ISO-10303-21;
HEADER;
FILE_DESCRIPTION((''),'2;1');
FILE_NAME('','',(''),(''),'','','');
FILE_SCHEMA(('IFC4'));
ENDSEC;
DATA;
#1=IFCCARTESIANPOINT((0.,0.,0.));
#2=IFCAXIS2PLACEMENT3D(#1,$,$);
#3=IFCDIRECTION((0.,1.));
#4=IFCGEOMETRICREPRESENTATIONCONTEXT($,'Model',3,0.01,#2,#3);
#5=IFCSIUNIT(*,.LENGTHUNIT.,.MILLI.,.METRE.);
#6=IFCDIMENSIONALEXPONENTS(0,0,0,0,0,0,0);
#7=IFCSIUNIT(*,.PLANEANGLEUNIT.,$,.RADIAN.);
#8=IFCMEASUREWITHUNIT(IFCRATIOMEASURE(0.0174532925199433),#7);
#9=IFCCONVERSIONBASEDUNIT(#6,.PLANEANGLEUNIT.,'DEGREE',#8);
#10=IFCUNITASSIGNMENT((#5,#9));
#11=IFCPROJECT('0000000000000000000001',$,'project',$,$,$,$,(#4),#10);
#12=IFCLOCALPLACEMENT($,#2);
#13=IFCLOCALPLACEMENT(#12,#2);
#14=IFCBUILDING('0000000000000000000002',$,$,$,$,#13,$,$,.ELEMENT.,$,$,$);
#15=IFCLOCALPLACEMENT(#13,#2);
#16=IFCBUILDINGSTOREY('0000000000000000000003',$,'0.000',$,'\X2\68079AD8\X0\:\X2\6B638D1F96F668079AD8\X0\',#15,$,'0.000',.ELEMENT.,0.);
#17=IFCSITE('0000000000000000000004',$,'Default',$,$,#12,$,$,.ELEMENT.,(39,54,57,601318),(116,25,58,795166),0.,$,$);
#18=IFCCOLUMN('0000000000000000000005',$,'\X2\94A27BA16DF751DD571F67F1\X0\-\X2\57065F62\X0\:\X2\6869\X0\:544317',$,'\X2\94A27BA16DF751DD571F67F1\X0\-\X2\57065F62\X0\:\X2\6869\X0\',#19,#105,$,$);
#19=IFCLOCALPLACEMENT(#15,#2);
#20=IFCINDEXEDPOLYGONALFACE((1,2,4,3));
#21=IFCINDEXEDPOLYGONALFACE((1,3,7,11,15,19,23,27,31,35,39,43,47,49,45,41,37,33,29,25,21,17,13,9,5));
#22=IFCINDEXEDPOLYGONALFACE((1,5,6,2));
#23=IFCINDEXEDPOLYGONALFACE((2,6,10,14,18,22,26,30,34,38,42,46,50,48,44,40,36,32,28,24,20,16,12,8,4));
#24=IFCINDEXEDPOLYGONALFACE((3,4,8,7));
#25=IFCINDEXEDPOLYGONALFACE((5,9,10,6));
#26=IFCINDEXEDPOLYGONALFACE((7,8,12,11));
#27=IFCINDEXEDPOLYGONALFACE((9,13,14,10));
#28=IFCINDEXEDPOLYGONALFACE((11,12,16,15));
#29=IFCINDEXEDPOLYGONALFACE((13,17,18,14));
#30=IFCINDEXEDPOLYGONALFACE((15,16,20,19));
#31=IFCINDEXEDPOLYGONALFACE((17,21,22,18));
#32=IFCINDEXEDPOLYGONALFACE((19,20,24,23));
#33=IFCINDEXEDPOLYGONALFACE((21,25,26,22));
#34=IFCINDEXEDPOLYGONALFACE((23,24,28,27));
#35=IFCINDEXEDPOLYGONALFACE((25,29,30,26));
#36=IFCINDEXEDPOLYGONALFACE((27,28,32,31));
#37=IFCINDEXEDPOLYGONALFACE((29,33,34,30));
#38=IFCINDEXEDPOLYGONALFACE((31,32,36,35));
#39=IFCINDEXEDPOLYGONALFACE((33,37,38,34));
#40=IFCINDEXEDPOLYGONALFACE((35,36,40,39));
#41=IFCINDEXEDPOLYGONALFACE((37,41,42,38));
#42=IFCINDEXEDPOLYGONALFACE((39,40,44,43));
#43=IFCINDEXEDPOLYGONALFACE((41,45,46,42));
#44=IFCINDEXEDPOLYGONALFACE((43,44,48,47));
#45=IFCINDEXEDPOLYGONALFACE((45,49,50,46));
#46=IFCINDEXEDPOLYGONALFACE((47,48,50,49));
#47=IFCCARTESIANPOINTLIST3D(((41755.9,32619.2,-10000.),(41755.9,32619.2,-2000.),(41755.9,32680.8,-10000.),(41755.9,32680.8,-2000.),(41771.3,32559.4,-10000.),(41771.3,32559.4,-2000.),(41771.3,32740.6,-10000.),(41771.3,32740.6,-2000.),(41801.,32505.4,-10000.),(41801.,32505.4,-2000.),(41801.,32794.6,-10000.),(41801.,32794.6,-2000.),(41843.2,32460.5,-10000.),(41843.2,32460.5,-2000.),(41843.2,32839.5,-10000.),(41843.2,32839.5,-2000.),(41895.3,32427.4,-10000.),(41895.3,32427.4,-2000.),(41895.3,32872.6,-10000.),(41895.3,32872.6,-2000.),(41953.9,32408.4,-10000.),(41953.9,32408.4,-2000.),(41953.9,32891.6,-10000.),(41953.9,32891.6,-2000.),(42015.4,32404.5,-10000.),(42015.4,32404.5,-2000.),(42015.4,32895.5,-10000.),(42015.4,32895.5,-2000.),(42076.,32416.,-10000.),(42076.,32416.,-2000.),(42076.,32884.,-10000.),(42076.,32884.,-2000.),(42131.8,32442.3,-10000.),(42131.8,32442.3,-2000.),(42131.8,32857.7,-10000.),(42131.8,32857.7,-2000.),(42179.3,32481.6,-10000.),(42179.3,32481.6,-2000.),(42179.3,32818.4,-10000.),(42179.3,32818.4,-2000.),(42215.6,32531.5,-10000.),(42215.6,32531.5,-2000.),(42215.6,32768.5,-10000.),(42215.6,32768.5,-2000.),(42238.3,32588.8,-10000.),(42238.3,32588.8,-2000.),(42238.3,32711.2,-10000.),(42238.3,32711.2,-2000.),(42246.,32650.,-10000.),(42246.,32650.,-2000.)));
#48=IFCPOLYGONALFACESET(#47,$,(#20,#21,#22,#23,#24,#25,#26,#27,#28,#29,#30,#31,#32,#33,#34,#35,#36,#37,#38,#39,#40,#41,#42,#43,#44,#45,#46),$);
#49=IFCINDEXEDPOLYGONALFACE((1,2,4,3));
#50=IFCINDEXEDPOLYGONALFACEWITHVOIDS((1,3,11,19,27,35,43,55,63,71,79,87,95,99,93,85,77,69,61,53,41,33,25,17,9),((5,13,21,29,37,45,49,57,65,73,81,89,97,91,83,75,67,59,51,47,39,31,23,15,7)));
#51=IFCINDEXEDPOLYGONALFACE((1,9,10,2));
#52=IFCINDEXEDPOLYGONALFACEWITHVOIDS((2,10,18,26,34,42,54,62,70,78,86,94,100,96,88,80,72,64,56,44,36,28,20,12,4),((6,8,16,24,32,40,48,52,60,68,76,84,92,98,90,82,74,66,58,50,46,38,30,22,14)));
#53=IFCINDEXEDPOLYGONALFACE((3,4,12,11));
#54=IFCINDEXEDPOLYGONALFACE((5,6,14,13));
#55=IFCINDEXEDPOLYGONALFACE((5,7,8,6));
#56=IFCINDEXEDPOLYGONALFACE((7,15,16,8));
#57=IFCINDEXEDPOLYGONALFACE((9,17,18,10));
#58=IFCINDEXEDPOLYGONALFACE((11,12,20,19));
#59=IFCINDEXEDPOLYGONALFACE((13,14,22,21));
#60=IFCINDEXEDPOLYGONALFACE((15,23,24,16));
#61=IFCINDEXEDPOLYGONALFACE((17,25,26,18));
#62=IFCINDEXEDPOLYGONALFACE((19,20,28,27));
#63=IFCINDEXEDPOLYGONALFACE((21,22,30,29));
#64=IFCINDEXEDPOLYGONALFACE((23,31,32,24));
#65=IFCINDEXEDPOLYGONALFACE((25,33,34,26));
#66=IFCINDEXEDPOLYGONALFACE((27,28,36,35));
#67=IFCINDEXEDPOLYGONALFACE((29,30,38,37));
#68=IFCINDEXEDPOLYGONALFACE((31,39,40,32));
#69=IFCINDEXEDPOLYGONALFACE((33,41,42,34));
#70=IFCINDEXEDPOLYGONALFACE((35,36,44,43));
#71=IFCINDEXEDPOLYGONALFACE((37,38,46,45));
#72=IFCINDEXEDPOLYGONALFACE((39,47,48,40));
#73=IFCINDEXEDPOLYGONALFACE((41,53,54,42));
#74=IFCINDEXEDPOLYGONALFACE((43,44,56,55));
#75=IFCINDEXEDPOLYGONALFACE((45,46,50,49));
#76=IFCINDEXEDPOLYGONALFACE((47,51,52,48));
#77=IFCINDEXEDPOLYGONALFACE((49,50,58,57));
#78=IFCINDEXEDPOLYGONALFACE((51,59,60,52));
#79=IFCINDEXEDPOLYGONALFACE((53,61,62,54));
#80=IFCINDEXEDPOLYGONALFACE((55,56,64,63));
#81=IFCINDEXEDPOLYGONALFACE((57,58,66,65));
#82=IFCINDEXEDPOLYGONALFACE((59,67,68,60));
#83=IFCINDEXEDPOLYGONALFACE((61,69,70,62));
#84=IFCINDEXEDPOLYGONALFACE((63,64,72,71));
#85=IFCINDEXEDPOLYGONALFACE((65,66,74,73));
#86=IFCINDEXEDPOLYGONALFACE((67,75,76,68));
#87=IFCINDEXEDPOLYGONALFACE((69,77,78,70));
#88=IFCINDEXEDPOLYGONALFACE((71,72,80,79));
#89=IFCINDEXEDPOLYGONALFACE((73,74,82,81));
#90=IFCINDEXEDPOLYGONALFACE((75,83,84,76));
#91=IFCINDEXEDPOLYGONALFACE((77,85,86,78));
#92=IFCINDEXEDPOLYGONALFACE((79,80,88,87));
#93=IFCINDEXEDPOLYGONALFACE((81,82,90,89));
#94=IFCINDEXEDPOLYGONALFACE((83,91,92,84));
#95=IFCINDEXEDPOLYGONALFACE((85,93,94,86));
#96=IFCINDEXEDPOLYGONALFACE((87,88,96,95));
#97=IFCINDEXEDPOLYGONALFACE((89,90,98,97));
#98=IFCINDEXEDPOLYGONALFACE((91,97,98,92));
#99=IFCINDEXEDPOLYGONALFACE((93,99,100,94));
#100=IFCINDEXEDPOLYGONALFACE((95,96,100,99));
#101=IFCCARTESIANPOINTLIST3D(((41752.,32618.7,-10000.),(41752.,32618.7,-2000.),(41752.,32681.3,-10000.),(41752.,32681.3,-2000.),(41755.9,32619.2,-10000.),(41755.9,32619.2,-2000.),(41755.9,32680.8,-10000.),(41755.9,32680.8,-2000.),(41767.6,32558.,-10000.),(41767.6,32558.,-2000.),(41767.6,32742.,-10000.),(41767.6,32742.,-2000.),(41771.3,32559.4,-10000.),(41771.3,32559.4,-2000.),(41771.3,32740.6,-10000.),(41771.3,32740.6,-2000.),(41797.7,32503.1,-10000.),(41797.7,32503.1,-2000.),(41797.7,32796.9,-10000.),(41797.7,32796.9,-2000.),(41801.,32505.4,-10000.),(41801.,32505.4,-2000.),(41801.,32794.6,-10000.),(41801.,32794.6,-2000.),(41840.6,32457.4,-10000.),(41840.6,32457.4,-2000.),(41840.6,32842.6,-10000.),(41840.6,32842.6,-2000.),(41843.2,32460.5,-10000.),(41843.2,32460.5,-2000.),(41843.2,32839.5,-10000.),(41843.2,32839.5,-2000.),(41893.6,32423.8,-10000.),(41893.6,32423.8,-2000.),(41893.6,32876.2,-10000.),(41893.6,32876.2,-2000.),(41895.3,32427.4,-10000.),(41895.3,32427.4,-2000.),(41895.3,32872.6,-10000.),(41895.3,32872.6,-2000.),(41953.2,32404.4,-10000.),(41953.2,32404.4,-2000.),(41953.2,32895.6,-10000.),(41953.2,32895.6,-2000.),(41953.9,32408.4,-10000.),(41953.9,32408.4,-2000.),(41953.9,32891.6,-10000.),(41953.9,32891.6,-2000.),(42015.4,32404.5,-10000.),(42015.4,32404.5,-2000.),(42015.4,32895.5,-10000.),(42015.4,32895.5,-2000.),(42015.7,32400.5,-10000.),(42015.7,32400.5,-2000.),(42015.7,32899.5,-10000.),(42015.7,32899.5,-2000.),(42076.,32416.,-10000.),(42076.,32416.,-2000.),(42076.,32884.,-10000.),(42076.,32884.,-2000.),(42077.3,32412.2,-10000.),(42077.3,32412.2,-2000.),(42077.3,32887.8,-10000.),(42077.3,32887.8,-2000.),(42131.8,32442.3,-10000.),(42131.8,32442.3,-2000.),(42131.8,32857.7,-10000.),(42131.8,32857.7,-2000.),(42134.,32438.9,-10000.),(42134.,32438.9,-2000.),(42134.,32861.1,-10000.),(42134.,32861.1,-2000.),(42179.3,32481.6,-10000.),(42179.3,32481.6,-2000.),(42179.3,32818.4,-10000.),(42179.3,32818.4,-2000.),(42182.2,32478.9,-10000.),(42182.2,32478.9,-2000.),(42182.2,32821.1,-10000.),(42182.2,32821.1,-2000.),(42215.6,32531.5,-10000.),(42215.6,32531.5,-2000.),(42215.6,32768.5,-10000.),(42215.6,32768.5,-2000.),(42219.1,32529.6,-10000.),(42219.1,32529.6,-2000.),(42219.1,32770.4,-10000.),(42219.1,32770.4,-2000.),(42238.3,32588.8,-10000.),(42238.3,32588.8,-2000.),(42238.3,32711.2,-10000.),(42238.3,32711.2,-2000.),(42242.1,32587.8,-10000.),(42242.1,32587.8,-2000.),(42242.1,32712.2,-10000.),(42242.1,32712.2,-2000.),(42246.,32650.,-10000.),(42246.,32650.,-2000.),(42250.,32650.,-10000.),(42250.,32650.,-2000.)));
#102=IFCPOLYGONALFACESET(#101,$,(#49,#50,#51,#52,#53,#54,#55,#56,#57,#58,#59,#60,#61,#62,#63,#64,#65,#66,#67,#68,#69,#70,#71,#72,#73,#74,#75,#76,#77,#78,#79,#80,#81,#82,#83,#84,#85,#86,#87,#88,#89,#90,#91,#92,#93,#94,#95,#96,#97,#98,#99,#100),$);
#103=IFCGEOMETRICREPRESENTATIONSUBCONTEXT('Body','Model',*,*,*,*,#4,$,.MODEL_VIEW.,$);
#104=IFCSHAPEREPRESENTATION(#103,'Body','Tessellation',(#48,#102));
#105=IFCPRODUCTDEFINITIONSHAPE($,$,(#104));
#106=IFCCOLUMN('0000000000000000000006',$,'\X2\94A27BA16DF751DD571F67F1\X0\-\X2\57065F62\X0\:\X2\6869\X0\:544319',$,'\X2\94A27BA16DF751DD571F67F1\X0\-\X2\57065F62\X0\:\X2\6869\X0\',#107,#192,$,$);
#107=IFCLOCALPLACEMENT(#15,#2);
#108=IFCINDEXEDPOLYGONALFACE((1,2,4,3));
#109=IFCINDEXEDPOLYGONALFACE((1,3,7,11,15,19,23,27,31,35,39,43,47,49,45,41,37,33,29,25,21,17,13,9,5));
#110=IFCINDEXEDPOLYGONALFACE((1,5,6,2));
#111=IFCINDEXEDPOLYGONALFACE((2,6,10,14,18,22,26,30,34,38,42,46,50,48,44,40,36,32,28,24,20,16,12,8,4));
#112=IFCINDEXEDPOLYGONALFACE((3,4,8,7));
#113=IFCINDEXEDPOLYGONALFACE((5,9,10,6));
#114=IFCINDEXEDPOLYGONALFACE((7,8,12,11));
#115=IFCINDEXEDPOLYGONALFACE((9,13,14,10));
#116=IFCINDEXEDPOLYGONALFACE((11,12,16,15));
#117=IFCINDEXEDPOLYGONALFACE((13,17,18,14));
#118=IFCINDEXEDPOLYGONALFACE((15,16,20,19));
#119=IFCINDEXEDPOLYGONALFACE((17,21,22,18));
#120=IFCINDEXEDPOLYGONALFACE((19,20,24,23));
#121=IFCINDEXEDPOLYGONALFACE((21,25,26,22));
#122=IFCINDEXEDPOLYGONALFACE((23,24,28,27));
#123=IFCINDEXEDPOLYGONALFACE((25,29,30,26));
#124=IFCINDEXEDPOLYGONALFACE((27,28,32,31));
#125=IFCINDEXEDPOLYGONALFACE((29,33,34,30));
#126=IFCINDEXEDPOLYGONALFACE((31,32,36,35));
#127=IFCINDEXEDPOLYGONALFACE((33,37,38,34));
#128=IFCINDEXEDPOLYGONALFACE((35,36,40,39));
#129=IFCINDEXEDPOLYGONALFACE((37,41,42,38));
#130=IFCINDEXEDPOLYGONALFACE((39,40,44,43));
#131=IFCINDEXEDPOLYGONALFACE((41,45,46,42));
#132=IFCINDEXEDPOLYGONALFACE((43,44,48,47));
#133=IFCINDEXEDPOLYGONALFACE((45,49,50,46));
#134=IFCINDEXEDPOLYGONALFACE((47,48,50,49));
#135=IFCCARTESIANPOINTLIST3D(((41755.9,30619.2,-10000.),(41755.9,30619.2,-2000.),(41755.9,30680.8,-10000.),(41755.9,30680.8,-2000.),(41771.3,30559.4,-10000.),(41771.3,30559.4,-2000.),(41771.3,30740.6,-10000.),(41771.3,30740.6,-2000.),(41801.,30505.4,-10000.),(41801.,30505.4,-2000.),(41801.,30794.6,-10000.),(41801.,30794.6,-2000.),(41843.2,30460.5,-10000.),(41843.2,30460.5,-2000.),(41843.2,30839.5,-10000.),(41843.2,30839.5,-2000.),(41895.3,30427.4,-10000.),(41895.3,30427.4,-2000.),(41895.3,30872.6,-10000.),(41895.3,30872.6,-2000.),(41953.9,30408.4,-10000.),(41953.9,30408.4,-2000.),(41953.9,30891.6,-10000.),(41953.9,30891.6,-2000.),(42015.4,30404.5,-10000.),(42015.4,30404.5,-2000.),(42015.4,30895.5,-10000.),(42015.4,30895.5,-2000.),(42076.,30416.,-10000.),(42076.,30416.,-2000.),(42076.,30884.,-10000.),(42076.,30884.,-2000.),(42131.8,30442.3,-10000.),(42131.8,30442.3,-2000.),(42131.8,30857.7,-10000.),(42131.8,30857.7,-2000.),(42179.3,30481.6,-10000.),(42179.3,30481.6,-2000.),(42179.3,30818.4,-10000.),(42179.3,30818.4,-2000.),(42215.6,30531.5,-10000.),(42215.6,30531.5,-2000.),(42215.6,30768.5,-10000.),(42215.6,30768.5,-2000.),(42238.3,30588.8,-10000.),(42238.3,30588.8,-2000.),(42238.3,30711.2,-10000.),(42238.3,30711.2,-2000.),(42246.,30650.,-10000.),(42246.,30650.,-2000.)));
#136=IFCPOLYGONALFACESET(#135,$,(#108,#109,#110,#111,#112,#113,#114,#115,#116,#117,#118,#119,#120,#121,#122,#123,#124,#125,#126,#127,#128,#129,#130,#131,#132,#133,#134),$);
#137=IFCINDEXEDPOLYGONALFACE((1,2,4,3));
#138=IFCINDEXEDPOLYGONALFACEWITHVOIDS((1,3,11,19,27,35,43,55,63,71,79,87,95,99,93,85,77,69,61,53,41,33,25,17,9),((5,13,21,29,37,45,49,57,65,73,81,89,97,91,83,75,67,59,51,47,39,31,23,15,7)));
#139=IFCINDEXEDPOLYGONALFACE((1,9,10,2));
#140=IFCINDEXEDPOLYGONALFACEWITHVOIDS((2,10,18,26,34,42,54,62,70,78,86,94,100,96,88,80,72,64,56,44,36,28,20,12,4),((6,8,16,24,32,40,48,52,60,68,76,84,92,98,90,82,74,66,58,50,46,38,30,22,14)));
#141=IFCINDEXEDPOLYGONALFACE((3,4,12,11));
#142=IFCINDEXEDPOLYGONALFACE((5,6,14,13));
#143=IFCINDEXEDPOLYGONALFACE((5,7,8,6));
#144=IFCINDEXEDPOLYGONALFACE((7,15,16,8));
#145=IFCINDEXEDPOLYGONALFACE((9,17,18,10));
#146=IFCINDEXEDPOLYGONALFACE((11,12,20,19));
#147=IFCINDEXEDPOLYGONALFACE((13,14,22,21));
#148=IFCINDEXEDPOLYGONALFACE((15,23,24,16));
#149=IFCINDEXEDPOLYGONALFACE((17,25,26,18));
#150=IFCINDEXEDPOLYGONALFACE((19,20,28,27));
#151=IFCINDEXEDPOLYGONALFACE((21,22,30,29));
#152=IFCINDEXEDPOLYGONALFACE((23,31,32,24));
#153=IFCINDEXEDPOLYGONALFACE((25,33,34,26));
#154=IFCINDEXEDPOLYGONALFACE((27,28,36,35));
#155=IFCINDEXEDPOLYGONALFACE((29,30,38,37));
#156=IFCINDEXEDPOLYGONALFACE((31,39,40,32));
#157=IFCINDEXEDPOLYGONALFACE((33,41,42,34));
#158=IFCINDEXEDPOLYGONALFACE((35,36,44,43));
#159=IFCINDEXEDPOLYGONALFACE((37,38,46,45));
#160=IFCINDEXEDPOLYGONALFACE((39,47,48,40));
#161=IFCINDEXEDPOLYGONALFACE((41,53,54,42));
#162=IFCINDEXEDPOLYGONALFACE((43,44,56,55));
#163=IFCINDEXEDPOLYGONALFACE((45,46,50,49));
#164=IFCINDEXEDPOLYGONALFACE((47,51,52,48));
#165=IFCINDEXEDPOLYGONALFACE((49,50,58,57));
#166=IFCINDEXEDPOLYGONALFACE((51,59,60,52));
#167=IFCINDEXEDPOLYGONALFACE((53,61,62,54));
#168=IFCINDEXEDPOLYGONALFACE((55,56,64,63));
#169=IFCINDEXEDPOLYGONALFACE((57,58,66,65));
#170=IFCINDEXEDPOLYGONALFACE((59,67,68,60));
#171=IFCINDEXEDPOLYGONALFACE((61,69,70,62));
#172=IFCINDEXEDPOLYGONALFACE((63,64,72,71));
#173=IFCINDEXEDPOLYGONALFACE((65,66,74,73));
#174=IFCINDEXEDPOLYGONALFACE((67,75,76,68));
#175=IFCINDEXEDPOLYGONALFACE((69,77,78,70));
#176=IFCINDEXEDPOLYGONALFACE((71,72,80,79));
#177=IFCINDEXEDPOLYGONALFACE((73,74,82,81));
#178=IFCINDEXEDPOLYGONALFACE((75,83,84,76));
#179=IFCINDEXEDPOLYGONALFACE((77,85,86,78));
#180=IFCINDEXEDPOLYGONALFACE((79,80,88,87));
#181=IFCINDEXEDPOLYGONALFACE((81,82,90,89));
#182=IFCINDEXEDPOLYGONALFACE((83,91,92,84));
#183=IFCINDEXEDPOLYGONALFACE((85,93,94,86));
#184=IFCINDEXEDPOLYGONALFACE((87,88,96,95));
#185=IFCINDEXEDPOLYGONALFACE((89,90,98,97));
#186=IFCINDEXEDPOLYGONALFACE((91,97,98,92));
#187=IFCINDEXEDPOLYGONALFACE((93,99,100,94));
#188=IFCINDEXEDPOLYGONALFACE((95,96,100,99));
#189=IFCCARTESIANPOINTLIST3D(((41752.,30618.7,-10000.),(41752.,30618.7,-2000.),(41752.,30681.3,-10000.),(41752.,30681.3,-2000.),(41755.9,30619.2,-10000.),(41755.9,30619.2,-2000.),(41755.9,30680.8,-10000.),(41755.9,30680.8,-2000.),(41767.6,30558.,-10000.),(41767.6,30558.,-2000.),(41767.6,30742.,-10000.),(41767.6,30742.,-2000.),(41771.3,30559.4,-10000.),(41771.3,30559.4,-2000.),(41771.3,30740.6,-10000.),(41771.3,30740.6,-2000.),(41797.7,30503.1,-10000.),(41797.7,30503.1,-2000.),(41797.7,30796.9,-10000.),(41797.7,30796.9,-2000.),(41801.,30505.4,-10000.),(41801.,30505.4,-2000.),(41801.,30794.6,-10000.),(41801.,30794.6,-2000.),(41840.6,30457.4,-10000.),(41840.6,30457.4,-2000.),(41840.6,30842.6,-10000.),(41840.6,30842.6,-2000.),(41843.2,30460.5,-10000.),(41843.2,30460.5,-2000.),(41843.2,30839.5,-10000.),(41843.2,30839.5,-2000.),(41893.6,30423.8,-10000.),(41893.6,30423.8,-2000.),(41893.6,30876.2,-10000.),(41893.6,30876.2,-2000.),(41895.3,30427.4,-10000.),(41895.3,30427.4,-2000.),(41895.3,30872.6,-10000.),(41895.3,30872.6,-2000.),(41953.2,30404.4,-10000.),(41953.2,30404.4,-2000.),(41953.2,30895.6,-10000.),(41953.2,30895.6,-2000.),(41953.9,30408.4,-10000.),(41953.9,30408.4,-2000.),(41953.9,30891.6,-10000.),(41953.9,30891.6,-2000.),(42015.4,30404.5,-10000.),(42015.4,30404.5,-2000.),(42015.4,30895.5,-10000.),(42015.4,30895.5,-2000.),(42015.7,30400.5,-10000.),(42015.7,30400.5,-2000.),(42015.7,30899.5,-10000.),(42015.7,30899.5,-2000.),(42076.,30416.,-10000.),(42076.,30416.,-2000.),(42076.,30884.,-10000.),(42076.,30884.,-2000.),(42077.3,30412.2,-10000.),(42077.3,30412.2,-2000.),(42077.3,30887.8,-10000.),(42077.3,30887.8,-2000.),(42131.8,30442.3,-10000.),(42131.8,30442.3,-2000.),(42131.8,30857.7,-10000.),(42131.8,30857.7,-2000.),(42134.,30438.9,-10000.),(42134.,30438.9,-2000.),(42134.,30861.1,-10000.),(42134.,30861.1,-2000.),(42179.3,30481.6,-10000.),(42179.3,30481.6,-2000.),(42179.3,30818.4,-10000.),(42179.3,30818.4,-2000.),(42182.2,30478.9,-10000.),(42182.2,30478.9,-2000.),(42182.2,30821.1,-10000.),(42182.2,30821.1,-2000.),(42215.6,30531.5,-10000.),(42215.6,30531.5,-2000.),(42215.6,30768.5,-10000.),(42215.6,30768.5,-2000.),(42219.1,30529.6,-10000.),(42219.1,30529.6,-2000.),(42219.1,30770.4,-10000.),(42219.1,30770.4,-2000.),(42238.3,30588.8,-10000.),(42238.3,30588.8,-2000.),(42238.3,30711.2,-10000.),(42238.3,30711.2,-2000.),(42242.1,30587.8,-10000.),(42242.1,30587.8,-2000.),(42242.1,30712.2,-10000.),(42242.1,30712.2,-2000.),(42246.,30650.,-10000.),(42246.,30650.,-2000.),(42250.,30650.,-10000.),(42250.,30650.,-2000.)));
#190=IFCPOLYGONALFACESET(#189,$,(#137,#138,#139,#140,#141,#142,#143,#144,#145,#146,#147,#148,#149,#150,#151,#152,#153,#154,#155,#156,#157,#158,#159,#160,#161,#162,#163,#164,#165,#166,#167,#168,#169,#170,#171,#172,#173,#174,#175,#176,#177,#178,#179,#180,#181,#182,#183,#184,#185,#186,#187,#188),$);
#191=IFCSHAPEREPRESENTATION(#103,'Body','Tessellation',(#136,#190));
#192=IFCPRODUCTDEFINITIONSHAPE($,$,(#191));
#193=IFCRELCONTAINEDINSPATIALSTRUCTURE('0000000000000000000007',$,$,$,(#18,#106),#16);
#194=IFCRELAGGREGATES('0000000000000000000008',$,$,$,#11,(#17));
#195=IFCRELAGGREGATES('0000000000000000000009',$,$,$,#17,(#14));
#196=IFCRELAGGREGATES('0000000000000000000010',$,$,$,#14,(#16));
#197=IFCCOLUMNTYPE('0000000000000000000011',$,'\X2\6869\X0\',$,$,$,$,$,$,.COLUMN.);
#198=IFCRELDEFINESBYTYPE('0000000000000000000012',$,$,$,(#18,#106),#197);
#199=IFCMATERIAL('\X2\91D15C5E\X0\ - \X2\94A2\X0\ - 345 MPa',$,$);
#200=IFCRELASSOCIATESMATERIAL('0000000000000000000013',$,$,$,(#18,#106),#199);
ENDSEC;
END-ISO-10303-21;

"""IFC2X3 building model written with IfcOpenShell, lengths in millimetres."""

from ifc_helpers import new_model, entity, si_unit, converted_unit, direction, frame, frame_2d, origin, place, context, subcontext, project, spatial, circle, hollow_circle, extrude, source, transform, mapped, material, type_object, type_shapes, element, save


model = new_model("IFC2X3")

# Units and contexts
model_context = context("Model", 3, precision=0.01, world=origin(), true_north=direction((0.0, 1.0)))
body_context = subcontext(model_context, "Body", "Model", "MODEL_VIEW")
ifc_project = project(units=[si_unit("LENGTHUNIT", "METRE", prefix="MILLI"), converted_unit("PLANEANGLEUNIT", "DEGREE", entity("IfcRatioMeasure", 0.0174532925199433), si_unit("PLANEANGLEUNIT", "RADIAN"), dimensions=[0, 0, 0, 0, 0, 0, 0])], contexts=[model_context])

# Site, building, storey
site_placement = place(None, origin())
site = spatial("IfcSite", under=ifc_project, at=site_placement, Name="Default", CompositionType="ELEMENT", RefLatitude=(39, 54, 57, 601318), RefLongitude=(116, 25, 58, 795166), RefElevation=0.0)
building_placement = place(site_placement, origin())
building = spatial("IfcBuilding", under=site, at=building_placement, CompositionType="ELEMENT")
storey_placement = place(building_placement, origin())
storey = spatial("IfcBuildingStorey", under=building, at=storey_placement, Name="0.000", ObjectType="标高:正负零标高", LongName="0.000", CompositionType="ELEMENT", Elevation=0.0)

# Columns
ifc_material_1 = material(Name="金属 - 钢 - 345 MPa")
column_type_1 = type_object("IfcColumnType", Name="桩", PredefinedType="COLUMN")
shared_shape_1 = source(origin(), body_context, "Body", "SweptSolid", [
    extrude(circle(Radius=246.0, at=frame_2d((0.0, 0.0), x_axis=(1.0, 0.0))), frame((0.0, 0.0, -10000.0)), (0.0, 0.0, 1.0), 8000.0),
    extrude(hollow_circle(Radius=250.0, WallThickness=4.0, at=frame_2d((0.0, 0.0), x_axis=(1.0, 0.0))), frame((0.0, 0.0, -10000.0)), (0.0, 0.0, 1.0), 8000.0),
])
type_shapes(column_type_1, [shared_shape_1])
for number, where, name in (
    (1, (42000.0, 32650.0, 0.0), "钢管混凝土柱-圆形:桩:544317"),
    (2, (42000.0, 30650.0, 0.0), "钢管混凝土柱-圆形:桩:544319"),
):
    element("IfcColumn", number, at=place(storey_placement, frame(where)), inside=storey, type_object=column_type_1, material=ifc_material_1, Name=name, ObjectType="钢管混凝土柱-圆形:桩", context=body_context, shape_type="MappedRepresentation", body=[
        mapped(shared_shape_1, transform((0.0, 0.0, 0.0), scale=1.0)),
    ])

save(model, "model.ifc")
